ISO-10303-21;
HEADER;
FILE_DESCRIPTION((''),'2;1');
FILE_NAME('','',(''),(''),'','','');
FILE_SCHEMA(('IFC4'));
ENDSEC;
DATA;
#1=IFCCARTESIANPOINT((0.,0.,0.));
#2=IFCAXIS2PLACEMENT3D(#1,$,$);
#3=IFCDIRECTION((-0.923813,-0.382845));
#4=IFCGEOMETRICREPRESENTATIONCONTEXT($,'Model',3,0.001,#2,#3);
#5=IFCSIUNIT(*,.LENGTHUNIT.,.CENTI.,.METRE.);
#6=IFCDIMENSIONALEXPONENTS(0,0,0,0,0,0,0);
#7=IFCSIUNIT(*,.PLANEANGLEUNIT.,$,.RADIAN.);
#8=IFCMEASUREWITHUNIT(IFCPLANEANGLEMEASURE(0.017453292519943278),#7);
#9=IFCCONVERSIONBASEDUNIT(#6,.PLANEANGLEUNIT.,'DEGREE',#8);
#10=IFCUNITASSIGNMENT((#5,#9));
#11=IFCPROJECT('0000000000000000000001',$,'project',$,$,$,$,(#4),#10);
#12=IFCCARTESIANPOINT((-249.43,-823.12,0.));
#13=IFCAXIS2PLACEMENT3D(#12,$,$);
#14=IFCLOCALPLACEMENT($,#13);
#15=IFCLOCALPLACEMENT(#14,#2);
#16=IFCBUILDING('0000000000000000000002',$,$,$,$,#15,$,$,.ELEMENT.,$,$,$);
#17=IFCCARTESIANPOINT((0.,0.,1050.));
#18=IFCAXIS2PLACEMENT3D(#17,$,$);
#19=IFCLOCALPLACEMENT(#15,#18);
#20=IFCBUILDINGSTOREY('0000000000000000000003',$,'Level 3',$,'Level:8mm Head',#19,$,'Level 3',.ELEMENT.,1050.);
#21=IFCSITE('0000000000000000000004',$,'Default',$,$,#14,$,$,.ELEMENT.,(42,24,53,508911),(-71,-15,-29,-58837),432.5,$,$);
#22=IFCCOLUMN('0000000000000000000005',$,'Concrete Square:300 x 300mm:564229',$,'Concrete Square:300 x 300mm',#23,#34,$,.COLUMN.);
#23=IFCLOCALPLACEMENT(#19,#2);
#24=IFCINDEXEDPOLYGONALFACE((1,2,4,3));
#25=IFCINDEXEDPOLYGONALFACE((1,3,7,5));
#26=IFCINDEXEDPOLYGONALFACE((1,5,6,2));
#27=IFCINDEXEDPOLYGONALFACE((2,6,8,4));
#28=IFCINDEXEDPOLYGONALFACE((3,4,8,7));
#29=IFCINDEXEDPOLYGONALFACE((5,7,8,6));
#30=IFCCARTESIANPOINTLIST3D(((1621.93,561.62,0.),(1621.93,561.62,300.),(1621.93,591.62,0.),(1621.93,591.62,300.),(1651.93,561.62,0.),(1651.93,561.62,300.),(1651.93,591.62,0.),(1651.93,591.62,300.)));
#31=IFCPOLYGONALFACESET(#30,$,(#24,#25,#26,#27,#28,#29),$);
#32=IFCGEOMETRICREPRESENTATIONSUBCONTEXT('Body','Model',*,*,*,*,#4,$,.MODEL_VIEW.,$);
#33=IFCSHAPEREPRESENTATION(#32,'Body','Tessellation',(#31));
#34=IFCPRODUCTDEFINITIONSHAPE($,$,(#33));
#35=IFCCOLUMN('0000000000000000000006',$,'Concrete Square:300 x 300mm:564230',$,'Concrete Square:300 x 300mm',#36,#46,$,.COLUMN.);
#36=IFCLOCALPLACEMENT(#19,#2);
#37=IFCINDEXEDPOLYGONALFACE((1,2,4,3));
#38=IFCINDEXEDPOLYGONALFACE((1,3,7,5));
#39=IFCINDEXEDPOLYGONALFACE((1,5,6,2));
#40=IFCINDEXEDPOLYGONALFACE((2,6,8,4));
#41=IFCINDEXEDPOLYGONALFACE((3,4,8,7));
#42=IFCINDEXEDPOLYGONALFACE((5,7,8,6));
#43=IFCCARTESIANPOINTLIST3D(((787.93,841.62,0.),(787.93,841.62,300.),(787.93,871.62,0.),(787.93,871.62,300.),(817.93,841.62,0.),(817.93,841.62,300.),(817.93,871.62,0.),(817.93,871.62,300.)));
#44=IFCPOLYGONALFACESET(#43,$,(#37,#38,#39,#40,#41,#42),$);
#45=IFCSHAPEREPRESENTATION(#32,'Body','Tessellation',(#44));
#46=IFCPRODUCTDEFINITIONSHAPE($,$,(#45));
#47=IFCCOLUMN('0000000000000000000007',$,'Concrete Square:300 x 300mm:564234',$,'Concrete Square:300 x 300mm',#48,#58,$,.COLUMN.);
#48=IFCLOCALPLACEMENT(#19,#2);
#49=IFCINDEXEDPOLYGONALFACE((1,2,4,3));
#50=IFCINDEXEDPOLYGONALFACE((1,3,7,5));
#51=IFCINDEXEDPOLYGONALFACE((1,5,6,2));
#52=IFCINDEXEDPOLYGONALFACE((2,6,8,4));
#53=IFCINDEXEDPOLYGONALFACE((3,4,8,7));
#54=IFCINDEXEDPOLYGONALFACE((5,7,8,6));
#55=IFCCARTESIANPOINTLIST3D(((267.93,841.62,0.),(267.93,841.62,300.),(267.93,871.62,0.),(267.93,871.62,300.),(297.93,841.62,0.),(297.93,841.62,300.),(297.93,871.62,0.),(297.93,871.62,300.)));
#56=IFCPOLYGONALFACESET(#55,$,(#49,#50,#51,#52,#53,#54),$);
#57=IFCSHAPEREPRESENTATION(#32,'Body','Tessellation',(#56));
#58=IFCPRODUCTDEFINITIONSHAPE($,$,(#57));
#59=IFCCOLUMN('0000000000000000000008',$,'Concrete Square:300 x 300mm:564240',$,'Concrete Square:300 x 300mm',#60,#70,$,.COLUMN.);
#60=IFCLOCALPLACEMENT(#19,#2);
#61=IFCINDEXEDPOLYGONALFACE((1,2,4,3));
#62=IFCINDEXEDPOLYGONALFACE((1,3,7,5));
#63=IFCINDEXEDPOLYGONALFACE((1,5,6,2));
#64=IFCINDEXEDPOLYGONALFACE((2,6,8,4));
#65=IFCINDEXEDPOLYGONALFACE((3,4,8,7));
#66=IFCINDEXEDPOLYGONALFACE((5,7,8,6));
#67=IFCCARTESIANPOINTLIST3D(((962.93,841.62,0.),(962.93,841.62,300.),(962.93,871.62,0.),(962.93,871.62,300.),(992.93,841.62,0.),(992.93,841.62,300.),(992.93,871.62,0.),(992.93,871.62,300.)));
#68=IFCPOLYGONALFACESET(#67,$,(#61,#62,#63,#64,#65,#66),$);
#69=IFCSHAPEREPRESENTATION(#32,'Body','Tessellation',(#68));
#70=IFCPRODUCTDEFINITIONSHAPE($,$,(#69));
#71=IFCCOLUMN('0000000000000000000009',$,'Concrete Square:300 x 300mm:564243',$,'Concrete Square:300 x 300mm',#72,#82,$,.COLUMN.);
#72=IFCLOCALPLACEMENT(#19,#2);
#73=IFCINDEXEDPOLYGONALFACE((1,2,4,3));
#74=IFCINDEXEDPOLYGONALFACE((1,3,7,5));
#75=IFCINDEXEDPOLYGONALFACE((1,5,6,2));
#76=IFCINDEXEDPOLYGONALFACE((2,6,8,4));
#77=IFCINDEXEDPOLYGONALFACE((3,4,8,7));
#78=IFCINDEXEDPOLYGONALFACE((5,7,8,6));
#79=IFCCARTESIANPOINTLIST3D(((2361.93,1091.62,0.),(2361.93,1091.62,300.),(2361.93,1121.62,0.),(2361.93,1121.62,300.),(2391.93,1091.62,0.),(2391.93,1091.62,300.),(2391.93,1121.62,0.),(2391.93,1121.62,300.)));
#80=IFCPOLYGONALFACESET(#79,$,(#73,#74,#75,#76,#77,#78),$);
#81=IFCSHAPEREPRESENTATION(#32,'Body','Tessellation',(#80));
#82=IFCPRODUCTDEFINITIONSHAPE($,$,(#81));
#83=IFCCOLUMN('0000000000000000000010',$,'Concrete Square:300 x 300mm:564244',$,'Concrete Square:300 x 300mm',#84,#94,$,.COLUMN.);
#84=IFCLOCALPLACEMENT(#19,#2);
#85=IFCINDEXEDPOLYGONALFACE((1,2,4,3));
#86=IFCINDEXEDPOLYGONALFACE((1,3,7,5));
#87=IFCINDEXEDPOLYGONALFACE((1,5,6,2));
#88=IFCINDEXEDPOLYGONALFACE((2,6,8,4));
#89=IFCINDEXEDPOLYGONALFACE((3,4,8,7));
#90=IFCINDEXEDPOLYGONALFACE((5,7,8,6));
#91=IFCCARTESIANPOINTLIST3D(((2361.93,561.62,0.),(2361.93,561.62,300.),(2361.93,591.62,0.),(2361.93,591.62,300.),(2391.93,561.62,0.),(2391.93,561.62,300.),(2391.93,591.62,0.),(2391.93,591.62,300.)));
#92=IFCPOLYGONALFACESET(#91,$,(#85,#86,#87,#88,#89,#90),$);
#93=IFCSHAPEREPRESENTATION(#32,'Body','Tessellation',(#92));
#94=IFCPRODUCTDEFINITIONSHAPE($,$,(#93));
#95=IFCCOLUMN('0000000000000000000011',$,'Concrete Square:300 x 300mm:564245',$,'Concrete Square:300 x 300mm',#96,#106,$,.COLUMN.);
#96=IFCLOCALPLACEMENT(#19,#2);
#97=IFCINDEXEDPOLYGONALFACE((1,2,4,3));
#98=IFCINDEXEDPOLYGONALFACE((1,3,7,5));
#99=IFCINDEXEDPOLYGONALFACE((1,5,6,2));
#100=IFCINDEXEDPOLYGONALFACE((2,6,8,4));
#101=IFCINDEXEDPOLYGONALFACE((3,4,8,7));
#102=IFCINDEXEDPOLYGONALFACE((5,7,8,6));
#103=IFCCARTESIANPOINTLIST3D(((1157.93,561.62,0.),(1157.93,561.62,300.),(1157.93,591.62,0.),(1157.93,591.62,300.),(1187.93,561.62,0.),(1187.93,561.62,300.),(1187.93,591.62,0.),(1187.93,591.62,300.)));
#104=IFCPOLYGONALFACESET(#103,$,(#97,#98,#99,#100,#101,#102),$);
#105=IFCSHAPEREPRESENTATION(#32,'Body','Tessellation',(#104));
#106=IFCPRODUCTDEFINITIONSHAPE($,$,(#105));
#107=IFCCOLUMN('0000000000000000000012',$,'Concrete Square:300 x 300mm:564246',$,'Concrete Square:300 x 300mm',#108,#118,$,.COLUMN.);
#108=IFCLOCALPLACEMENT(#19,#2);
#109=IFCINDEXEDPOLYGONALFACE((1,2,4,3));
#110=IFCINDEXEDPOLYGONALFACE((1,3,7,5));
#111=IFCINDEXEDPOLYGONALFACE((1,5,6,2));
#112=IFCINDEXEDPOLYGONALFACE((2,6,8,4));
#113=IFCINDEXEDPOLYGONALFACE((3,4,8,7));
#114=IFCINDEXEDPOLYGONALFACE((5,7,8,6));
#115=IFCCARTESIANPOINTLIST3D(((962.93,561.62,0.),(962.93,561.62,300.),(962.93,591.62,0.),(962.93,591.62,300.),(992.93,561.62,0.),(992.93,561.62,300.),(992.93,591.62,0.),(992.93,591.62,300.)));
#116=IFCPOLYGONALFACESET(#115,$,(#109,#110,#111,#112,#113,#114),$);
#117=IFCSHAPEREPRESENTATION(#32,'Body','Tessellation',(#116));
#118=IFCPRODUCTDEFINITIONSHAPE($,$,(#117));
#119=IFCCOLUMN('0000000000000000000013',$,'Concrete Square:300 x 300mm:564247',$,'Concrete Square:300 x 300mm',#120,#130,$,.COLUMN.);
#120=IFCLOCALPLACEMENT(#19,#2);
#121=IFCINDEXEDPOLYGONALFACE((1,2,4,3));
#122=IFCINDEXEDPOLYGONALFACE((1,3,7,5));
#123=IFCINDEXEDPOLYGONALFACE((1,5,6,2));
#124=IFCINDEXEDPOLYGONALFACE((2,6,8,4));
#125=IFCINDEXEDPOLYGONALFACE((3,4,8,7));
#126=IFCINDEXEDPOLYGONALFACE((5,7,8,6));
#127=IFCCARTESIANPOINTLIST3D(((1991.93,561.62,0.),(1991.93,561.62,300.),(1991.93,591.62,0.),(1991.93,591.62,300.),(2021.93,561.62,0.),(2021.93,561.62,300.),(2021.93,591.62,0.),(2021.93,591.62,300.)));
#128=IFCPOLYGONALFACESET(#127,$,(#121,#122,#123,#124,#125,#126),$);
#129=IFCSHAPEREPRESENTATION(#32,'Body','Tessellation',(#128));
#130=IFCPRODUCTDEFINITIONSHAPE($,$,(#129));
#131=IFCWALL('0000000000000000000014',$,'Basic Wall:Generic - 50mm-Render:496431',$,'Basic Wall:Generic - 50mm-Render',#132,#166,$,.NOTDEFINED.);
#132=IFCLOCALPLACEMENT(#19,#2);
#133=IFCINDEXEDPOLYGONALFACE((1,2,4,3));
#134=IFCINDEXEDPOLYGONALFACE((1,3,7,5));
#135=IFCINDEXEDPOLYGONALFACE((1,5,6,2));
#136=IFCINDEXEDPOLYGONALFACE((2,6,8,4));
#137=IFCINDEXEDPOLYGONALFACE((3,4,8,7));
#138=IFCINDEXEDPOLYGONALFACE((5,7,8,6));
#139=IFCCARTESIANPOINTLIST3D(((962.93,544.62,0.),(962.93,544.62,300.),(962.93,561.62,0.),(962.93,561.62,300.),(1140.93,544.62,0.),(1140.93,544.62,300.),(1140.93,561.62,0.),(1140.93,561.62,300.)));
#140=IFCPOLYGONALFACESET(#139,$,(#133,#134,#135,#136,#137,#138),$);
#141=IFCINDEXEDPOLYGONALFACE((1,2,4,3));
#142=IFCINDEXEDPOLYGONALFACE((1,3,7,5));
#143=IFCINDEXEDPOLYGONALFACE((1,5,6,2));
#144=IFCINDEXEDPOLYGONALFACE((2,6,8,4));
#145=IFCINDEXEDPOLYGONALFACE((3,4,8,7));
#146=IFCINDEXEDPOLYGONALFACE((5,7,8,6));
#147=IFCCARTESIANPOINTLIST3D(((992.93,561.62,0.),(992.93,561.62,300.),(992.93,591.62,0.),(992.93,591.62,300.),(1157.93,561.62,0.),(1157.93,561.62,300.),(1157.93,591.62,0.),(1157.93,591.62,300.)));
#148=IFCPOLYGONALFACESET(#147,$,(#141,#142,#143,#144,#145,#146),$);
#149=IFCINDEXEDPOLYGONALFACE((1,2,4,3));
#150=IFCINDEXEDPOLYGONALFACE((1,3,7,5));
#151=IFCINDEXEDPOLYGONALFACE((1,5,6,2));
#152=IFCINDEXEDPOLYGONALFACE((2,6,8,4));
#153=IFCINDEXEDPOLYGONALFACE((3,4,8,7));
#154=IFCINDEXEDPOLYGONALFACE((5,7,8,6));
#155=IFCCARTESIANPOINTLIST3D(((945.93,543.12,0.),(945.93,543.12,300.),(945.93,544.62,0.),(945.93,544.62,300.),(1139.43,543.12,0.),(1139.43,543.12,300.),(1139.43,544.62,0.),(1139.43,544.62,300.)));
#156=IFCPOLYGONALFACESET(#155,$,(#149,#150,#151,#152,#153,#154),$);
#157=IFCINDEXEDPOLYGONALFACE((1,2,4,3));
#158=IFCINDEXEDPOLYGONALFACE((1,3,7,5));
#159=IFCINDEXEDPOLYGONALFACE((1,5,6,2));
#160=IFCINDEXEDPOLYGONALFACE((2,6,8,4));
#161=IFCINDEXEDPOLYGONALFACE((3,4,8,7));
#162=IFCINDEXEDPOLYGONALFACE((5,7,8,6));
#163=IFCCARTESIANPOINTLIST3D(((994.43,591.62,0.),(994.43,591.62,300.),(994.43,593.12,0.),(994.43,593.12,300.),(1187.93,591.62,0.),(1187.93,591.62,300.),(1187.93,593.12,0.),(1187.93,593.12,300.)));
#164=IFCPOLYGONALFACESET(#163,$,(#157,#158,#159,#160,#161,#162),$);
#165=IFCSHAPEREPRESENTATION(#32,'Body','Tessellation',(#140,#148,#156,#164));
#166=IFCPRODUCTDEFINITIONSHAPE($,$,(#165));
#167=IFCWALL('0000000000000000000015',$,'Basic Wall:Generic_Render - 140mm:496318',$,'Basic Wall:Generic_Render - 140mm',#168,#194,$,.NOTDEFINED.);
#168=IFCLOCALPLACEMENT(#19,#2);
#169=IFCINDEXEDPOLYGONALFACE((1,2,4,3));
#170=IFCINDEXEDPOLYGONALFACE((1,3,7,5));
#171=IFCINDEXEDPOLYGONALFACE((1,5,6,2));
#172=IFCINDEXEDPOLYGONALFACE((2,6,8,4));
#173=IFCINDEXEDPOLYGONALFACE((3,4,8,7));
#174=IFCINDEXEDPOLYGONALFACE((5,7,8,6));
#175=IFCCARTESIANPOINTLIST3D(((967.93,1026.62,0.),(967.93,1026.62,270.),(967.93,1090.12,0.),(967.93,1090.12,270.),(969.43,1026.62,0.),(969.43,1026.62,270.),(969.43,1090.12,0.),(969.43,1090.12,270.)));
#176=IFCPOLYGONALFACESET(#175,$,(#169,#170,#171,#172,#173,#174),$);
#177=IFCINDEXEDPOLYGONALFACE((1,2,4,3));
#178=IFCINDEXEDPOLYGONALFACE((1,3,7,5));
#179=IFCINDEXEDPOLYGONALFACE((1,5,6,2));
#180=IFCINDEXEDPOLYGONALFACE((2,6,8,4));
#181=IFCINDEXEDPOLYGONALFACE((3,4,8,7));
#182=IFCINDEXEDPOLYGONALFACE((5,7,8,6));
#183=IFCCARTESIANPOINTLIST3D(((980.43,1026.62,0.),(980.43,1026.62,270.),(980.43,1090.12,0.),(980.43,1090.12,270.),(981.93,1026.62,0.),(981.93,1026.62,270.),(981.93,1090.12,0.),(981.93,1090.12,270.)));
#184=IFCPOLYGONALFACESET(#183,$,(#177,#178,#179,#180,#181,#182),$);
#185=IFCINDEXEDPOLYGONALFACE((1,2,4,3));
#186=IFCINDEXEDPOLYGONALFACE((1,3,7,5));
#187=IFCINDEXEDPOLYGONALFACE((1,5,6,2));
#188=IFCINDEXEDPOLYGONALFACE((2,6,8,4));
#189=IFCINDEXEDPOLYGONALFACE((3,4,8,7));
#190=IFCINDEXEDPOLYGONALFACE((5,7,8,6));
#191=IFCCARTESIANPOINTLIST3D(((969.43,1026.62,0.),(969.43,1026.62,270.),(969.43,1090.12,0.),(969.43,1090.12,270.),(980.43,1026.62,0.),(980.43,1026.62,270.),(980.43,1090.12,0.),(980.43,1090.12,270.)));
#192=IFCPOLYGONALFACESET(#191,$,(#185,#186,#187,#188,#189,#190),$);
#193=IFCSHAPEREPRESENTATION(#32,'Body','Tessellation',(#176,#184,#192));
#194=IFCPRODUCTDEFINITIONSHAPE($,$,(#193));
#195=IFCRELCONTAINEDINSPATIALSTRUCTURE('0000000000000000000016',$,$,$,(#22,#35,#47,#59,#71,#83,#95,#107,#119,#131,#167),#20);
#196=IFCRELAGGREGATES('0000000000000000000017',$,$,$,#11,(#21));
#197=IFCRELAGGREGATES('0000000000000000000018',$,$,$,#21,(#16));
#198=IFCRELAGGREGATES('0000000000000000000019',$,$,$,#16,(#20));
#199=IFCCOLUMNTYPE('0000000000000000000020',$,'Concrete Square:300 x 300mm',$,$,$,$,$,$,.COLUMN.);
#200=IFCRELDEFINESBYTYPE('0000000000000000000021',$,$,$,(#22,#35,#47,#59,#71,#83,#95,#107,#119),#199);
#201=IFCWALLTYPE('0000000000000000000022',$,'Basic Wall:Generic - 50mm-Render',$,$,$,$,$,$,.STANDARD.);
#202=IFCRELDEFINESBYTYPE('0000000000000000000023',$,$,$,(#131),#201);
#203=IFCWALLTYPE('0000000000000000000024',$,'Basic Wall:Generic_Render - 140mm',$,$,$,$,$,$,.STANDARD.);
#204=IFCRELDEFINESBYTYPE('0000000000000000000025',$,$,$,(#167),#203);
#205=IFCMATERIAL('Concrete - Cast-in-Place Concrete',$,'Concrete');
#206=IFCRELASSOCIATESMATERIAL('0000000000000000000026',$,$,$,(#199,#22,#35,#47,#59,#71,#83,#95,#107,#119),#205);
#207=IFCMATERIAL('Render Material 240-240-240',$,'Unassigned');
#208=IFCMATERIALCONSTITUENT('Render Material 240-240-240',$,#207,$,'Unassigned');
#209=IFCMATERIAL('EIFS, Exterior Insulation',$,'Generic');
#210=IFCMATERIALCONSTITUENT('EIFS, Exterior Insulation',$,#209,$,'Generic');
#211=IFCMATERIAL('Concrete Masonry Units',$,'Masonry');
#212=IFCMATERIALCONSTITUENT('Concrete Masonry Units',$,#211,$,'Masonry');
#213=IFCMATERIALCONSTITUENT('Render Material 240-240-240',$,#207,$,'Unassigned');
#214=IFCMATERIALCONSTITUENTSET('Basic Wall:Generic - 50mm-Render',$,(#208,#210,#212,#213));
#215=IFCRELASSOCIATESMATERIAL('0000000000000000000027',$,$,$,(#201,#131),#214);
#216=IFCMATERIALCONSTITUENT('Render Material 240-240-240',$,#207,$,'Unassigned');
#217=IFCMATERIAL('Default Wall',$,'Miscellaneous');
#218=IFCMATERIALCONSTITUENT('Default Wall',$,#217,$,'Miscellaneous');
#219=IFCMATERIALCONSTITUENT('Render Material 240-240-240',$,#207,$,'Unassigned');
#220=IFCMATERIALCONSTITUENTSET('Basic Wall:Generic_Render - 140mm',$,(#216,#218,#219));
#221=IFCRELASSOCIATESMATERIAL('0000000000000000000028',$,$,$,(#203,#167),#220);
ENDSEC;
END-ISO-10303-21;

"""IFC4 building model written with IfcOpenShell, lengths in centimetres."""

from ifc_helpers import new_model, entity, si_unit, converted_unit, direction, frame, origin, place, context, subcontext, project, spatial, indexed_curve, outline, extrude, source, transform, mapped, material, constituent, constituent_set, type_object, type_shapes, element, save


model = new_model("IFC4")

# Units and contexts
model_context = context("Model", 3, precision=0.001, world=origin(), true_north=direction((-0.923813, -0.382845)))
body_context = subcontext(model_context, "Body", "Model", "MODEL_VIEW")
ifc_project = project(units=[si_unit("LENGTHUNIT", "METRE", prefix="CENTI"), converted_unit("PLANEANGLEUNIT", "DEGREE", entity("IfcPlaneAngleMeasure", 0.017453292519943278), si_unit("PLANEANGLEUNIT", "RADIAN"), dimensions=[0, 0, 0, 0, 0, 0, 0])], contexts=[model_context])

# Site, building, storey
site_placement = place(None, frame((-249.43, -823.12, 0.0)))
site = spatial("IfcSite", under=ifc_project, at=site_placement, Name="Default", CompositionType="ELEMENT", RefLatitude=(42, 24, 53, 508911), RefLongitude=(-71, -15, -29, -58837), RefElevation=432.5)
building_placement = place(site_placement, origin())
building = spatial("IfcBuilding", under=site, at=building_placement, CompositionType="ELEMENT")
storey_placement = place(building_placement, frame((0.0, 0.0, 1050.0)))
storey = spatial("IfcBuildingStorey", under=building, at=storey_placement, Name="Level 3", ObjectType="Level:8mm Head", LongName="Level 3", CompositionType="ELEMENT", Elevation=1050.0)

# Columns
ifc_material_1 = material(Name="Concrete - Cast-in-Place Concrete", Category="Concrete")
column_type = type_object("IfcColumnType", Name="Concrete Square:300 x 300mm", PredefinedType="COLUMN", material=ifc_material_1)
shared_shape = source(origin(), body_context, "Body", "SweptSolid", [
    extrude(outline(indexed_curve([(-15.0, -15.0), (15.0, -15.0), (15.0, 15.0), (-15.0, 15.0), (-15.0, -15.0)], self_intersect=False)), frame((0.0, 0.0, 1050.0), z_axis=(0.0, 0.0, 1.0), x_axis=(-1.0, 0.0, 0.0)), (0.0, 0.0, 1.0), 300.0),
])
type_shapes(column_type, [shared_shape])
for number, where, name in (
    (1, (1636.93, 576.62, -1050.0), "Concrete Square:300 x 300mm:564229"),
    (2, (802.93, 856.62, -1050.0), "Concrete Square:300 x 300mm:564230"),
    (3, (282.93, 856.62, -1050.0), "Concrete Square:300 x 300mm:564234"),
    (4, (977.93, 856.62, -1050.0), "Concrete Square:300 x 300mm:564240"),
    (5, (2376.93, 1106.62, -1050.0), "Concrete Square:300 x 300mm:564243"),
    (6, (2376.93, 576.62, -1050.0), "Concrete Square:300 x 300mm:564244"),
    (7, (1172.93, 576.62, -1050.0), "Concrete Square:300 x 300mm:564245"),
    (8, (977.93, 576.62, -1050.0), "Concrete Square:300 x 300mm:564246"),
    (9, (2006.93, 576.62, -1050.0), "Concrete Square:300 x 300mm:564247"),
):
    element("IfcColumn", number, at=place(storey_placement, frame(where)), inside=storey, type_object=column_type, material=ifc_material_1, Name=name, ObjectType="Concrete Square:300 x 300mm", PredefinedType="COLUMN", context=body_context, shape_type="MappedRepresentation", body=[
        mapped(shared_shape, transform((0.0, 0.0, 0.0), scale=1.0)),
    ])

# Walls
ifc_material_2 = material(Name="Render Material 240-240-240", Category="Unassigned")
ifc_material_3 = material(Name="Default Wall", Category="Miscellaneous")
ifc_constituent_1 = constituent(ifc_material_2, Name="Render Material 240-240-240", Category="Unassigned")
ifc_material_4 = material(Name="EIFS, Exterior Insulation", Category="Generic")
ifc_constituent_2 = constituent(ifc_material_4, Name="EIFS, Exterior Insulation", Category="Generic")
ifc_material_5 = material(Name="Concrete Masonry Units", Category="Masonry")
ifc_constituent_3 = constituent(ifc_material_5, Name="Concrete Masonry Units", Category="Masonry")
ifc_constituent_4 = constituent(ifc_material_2, Name="Render Material 240-240-240", Category="Unassigned")
ifc_constituent_set_1 = constituent_set(constituents=[ifc_constituent_1, ifc_constituent_2, ifc_constituent_3, ifc_constituent_4], Name="Basic Wall:Generic - 50mm-Render")
wall_type_1 = type_object("IfcWallType", Name="Basic Wall:Generic - 50mm-Render", PredefinedType="STANDARD", material=ifc_constituent_set_1)
wall_1_placement = place(storey_placement, frame((1139.43, 568.12, 0.0), z_axis=(0.0, 0.0, 1.0), x_axis=(-1.0, 0.0, 0.0)))
element("IfcWall", 10, at=wall_1_placement, inside=storey, type_object=wall_type_1, material=ifc_constituent_set_1, Name="Basic Wall:Generic - 50mm-Render:496431", ObjectType="Basic Wall:Generic - 50mm-Render", PredefinedType="NOTDEFINED", context=body_context, shape_type="SweptSolid", body=[
    extrude(outline(indexed_curve([(-89.0, -8.5), (89.0, -8.5), (89.0, 8.5), (-89.0, 8.5), (-89.0, -8.5)], self_intersect=False)), frame((87.5, 15.0, 0.0)), (0.0, 0.0, 1.0), 300.0),
    extrude(outline(indexed_curve([(-82.5, -15.0), (82.5, -15.0), (82.5, 15.0), (-82.5, 15.0), (-82.5, -15.0)], self_intersect=False)), frame((64.0, -8.5, 0.0)), (0.0, 0.0, 1.0), 300.0),
    extrude(outline(indexed_curve([(-0.75, -96.75), (0.75, -96.75), (0.75, 96.75), (-0.75, 96.75), (-0.75, -96.75)], self_intersect=False)), frame((96.75, 24.25, 0.0), z_axis=(0.0, 0.0, 1.0), x_axis=(0.0, -1.0, 0.0)), (0.0, 0.0, 1.0), 300.0),
    extrude(outline(indexed_curve([(-0.75, -96.75), (0.75, -96.75), (0.75, 96.75), (-0.75, 96.75), (-0.75, -96.75)], self_intersect=False)), frame((48.25, -24.25, 0.0), z_axis=(0.0, 0.0, 1.0), x_axis=(0.0, 1.0, 0.0)), (0.0, 0.0, 1.0), 300.0),
])
ifc_constituent_5 = constituent(ifc_material_2, Name="Render Material 240-240-240", Category="Unassigned")
ifc_constituent_6 = constituent(ifc_material_3, Name="Default Wall", Category="Miscellaneous")
ifc_constituent_7 = constituent(ifc_material_2, Name="Render Material 240-240-240", Category="Unassigned")
ifc_constituent_set_2 = constituent_set(constituents=[ifc_constituent_5, ifc_constituent_6, ifc_constituent_7], Name="Basic Wall:Generic_Render - 140mm")
wall_type_2 = type_object("IfcWallType", Name="Basic Wall:Generic_Render - 140mm", PredefinedType="STANDARD", material=ifc_constituent_set_2)
wall_2_placement = place(storey_placement, frame((974.93, 1090.12, 0.0), z_axis=(0.0, 0.0, 1.0), x_axis=(0.0, -1.0, 0.0)))
element("IfcWall", 11, at=wall_2_placement, inside=storey, type_object=wall_type_2, material=ifc_constituent_set_2, Name="Basic Wall:Generic_Render - 140mm:496318", ObjectType="Basic Wall:Generic_Render - 140mm", PredefinedType="NOTDEFINED", context=body_context, shape_type="SweptSolid", body=[
    extrude(outline(indexed_curve([(-0.75, -31.75), (0.75, -31.75), (0.75, 31.75), (-0.75, 31.75), (-0.75, -31.75)], self_intersect=False)), frame((31.75, -6.25, 0.0), z_axis=(0.0, 0.0, 1.0), x_axis=(0.0, 1.0, 0.0)), (0.0, 0.0, 1.0), 270.0),
    extrude(outline(indexed_curve([(-0.75, -31.75), (0.75, -31.75), (0.75, 31.75), (-0.75, 31.75), (-0.75, -31.75)], self_intersect=False)), frame((31.75, 6.25, 0.0), z_axis=(0.0, 0.0, 1.0), x_axis=(0.0, -1.0, 0.0)), (0.0, 0.0, 1.0), 270.0),
    extrude(outline(indexed_curve([(-31.75, -5.5), (31.75, -5.5), (31.75, 5.5), (-31.75, 5.5), (-31.75, -5.5)], self_intersect=False)), frame((31.75, 0.0, 0.0)), (0.0, 0.0, 1.0), 270.0),
])

save(model, "model.ifc")
